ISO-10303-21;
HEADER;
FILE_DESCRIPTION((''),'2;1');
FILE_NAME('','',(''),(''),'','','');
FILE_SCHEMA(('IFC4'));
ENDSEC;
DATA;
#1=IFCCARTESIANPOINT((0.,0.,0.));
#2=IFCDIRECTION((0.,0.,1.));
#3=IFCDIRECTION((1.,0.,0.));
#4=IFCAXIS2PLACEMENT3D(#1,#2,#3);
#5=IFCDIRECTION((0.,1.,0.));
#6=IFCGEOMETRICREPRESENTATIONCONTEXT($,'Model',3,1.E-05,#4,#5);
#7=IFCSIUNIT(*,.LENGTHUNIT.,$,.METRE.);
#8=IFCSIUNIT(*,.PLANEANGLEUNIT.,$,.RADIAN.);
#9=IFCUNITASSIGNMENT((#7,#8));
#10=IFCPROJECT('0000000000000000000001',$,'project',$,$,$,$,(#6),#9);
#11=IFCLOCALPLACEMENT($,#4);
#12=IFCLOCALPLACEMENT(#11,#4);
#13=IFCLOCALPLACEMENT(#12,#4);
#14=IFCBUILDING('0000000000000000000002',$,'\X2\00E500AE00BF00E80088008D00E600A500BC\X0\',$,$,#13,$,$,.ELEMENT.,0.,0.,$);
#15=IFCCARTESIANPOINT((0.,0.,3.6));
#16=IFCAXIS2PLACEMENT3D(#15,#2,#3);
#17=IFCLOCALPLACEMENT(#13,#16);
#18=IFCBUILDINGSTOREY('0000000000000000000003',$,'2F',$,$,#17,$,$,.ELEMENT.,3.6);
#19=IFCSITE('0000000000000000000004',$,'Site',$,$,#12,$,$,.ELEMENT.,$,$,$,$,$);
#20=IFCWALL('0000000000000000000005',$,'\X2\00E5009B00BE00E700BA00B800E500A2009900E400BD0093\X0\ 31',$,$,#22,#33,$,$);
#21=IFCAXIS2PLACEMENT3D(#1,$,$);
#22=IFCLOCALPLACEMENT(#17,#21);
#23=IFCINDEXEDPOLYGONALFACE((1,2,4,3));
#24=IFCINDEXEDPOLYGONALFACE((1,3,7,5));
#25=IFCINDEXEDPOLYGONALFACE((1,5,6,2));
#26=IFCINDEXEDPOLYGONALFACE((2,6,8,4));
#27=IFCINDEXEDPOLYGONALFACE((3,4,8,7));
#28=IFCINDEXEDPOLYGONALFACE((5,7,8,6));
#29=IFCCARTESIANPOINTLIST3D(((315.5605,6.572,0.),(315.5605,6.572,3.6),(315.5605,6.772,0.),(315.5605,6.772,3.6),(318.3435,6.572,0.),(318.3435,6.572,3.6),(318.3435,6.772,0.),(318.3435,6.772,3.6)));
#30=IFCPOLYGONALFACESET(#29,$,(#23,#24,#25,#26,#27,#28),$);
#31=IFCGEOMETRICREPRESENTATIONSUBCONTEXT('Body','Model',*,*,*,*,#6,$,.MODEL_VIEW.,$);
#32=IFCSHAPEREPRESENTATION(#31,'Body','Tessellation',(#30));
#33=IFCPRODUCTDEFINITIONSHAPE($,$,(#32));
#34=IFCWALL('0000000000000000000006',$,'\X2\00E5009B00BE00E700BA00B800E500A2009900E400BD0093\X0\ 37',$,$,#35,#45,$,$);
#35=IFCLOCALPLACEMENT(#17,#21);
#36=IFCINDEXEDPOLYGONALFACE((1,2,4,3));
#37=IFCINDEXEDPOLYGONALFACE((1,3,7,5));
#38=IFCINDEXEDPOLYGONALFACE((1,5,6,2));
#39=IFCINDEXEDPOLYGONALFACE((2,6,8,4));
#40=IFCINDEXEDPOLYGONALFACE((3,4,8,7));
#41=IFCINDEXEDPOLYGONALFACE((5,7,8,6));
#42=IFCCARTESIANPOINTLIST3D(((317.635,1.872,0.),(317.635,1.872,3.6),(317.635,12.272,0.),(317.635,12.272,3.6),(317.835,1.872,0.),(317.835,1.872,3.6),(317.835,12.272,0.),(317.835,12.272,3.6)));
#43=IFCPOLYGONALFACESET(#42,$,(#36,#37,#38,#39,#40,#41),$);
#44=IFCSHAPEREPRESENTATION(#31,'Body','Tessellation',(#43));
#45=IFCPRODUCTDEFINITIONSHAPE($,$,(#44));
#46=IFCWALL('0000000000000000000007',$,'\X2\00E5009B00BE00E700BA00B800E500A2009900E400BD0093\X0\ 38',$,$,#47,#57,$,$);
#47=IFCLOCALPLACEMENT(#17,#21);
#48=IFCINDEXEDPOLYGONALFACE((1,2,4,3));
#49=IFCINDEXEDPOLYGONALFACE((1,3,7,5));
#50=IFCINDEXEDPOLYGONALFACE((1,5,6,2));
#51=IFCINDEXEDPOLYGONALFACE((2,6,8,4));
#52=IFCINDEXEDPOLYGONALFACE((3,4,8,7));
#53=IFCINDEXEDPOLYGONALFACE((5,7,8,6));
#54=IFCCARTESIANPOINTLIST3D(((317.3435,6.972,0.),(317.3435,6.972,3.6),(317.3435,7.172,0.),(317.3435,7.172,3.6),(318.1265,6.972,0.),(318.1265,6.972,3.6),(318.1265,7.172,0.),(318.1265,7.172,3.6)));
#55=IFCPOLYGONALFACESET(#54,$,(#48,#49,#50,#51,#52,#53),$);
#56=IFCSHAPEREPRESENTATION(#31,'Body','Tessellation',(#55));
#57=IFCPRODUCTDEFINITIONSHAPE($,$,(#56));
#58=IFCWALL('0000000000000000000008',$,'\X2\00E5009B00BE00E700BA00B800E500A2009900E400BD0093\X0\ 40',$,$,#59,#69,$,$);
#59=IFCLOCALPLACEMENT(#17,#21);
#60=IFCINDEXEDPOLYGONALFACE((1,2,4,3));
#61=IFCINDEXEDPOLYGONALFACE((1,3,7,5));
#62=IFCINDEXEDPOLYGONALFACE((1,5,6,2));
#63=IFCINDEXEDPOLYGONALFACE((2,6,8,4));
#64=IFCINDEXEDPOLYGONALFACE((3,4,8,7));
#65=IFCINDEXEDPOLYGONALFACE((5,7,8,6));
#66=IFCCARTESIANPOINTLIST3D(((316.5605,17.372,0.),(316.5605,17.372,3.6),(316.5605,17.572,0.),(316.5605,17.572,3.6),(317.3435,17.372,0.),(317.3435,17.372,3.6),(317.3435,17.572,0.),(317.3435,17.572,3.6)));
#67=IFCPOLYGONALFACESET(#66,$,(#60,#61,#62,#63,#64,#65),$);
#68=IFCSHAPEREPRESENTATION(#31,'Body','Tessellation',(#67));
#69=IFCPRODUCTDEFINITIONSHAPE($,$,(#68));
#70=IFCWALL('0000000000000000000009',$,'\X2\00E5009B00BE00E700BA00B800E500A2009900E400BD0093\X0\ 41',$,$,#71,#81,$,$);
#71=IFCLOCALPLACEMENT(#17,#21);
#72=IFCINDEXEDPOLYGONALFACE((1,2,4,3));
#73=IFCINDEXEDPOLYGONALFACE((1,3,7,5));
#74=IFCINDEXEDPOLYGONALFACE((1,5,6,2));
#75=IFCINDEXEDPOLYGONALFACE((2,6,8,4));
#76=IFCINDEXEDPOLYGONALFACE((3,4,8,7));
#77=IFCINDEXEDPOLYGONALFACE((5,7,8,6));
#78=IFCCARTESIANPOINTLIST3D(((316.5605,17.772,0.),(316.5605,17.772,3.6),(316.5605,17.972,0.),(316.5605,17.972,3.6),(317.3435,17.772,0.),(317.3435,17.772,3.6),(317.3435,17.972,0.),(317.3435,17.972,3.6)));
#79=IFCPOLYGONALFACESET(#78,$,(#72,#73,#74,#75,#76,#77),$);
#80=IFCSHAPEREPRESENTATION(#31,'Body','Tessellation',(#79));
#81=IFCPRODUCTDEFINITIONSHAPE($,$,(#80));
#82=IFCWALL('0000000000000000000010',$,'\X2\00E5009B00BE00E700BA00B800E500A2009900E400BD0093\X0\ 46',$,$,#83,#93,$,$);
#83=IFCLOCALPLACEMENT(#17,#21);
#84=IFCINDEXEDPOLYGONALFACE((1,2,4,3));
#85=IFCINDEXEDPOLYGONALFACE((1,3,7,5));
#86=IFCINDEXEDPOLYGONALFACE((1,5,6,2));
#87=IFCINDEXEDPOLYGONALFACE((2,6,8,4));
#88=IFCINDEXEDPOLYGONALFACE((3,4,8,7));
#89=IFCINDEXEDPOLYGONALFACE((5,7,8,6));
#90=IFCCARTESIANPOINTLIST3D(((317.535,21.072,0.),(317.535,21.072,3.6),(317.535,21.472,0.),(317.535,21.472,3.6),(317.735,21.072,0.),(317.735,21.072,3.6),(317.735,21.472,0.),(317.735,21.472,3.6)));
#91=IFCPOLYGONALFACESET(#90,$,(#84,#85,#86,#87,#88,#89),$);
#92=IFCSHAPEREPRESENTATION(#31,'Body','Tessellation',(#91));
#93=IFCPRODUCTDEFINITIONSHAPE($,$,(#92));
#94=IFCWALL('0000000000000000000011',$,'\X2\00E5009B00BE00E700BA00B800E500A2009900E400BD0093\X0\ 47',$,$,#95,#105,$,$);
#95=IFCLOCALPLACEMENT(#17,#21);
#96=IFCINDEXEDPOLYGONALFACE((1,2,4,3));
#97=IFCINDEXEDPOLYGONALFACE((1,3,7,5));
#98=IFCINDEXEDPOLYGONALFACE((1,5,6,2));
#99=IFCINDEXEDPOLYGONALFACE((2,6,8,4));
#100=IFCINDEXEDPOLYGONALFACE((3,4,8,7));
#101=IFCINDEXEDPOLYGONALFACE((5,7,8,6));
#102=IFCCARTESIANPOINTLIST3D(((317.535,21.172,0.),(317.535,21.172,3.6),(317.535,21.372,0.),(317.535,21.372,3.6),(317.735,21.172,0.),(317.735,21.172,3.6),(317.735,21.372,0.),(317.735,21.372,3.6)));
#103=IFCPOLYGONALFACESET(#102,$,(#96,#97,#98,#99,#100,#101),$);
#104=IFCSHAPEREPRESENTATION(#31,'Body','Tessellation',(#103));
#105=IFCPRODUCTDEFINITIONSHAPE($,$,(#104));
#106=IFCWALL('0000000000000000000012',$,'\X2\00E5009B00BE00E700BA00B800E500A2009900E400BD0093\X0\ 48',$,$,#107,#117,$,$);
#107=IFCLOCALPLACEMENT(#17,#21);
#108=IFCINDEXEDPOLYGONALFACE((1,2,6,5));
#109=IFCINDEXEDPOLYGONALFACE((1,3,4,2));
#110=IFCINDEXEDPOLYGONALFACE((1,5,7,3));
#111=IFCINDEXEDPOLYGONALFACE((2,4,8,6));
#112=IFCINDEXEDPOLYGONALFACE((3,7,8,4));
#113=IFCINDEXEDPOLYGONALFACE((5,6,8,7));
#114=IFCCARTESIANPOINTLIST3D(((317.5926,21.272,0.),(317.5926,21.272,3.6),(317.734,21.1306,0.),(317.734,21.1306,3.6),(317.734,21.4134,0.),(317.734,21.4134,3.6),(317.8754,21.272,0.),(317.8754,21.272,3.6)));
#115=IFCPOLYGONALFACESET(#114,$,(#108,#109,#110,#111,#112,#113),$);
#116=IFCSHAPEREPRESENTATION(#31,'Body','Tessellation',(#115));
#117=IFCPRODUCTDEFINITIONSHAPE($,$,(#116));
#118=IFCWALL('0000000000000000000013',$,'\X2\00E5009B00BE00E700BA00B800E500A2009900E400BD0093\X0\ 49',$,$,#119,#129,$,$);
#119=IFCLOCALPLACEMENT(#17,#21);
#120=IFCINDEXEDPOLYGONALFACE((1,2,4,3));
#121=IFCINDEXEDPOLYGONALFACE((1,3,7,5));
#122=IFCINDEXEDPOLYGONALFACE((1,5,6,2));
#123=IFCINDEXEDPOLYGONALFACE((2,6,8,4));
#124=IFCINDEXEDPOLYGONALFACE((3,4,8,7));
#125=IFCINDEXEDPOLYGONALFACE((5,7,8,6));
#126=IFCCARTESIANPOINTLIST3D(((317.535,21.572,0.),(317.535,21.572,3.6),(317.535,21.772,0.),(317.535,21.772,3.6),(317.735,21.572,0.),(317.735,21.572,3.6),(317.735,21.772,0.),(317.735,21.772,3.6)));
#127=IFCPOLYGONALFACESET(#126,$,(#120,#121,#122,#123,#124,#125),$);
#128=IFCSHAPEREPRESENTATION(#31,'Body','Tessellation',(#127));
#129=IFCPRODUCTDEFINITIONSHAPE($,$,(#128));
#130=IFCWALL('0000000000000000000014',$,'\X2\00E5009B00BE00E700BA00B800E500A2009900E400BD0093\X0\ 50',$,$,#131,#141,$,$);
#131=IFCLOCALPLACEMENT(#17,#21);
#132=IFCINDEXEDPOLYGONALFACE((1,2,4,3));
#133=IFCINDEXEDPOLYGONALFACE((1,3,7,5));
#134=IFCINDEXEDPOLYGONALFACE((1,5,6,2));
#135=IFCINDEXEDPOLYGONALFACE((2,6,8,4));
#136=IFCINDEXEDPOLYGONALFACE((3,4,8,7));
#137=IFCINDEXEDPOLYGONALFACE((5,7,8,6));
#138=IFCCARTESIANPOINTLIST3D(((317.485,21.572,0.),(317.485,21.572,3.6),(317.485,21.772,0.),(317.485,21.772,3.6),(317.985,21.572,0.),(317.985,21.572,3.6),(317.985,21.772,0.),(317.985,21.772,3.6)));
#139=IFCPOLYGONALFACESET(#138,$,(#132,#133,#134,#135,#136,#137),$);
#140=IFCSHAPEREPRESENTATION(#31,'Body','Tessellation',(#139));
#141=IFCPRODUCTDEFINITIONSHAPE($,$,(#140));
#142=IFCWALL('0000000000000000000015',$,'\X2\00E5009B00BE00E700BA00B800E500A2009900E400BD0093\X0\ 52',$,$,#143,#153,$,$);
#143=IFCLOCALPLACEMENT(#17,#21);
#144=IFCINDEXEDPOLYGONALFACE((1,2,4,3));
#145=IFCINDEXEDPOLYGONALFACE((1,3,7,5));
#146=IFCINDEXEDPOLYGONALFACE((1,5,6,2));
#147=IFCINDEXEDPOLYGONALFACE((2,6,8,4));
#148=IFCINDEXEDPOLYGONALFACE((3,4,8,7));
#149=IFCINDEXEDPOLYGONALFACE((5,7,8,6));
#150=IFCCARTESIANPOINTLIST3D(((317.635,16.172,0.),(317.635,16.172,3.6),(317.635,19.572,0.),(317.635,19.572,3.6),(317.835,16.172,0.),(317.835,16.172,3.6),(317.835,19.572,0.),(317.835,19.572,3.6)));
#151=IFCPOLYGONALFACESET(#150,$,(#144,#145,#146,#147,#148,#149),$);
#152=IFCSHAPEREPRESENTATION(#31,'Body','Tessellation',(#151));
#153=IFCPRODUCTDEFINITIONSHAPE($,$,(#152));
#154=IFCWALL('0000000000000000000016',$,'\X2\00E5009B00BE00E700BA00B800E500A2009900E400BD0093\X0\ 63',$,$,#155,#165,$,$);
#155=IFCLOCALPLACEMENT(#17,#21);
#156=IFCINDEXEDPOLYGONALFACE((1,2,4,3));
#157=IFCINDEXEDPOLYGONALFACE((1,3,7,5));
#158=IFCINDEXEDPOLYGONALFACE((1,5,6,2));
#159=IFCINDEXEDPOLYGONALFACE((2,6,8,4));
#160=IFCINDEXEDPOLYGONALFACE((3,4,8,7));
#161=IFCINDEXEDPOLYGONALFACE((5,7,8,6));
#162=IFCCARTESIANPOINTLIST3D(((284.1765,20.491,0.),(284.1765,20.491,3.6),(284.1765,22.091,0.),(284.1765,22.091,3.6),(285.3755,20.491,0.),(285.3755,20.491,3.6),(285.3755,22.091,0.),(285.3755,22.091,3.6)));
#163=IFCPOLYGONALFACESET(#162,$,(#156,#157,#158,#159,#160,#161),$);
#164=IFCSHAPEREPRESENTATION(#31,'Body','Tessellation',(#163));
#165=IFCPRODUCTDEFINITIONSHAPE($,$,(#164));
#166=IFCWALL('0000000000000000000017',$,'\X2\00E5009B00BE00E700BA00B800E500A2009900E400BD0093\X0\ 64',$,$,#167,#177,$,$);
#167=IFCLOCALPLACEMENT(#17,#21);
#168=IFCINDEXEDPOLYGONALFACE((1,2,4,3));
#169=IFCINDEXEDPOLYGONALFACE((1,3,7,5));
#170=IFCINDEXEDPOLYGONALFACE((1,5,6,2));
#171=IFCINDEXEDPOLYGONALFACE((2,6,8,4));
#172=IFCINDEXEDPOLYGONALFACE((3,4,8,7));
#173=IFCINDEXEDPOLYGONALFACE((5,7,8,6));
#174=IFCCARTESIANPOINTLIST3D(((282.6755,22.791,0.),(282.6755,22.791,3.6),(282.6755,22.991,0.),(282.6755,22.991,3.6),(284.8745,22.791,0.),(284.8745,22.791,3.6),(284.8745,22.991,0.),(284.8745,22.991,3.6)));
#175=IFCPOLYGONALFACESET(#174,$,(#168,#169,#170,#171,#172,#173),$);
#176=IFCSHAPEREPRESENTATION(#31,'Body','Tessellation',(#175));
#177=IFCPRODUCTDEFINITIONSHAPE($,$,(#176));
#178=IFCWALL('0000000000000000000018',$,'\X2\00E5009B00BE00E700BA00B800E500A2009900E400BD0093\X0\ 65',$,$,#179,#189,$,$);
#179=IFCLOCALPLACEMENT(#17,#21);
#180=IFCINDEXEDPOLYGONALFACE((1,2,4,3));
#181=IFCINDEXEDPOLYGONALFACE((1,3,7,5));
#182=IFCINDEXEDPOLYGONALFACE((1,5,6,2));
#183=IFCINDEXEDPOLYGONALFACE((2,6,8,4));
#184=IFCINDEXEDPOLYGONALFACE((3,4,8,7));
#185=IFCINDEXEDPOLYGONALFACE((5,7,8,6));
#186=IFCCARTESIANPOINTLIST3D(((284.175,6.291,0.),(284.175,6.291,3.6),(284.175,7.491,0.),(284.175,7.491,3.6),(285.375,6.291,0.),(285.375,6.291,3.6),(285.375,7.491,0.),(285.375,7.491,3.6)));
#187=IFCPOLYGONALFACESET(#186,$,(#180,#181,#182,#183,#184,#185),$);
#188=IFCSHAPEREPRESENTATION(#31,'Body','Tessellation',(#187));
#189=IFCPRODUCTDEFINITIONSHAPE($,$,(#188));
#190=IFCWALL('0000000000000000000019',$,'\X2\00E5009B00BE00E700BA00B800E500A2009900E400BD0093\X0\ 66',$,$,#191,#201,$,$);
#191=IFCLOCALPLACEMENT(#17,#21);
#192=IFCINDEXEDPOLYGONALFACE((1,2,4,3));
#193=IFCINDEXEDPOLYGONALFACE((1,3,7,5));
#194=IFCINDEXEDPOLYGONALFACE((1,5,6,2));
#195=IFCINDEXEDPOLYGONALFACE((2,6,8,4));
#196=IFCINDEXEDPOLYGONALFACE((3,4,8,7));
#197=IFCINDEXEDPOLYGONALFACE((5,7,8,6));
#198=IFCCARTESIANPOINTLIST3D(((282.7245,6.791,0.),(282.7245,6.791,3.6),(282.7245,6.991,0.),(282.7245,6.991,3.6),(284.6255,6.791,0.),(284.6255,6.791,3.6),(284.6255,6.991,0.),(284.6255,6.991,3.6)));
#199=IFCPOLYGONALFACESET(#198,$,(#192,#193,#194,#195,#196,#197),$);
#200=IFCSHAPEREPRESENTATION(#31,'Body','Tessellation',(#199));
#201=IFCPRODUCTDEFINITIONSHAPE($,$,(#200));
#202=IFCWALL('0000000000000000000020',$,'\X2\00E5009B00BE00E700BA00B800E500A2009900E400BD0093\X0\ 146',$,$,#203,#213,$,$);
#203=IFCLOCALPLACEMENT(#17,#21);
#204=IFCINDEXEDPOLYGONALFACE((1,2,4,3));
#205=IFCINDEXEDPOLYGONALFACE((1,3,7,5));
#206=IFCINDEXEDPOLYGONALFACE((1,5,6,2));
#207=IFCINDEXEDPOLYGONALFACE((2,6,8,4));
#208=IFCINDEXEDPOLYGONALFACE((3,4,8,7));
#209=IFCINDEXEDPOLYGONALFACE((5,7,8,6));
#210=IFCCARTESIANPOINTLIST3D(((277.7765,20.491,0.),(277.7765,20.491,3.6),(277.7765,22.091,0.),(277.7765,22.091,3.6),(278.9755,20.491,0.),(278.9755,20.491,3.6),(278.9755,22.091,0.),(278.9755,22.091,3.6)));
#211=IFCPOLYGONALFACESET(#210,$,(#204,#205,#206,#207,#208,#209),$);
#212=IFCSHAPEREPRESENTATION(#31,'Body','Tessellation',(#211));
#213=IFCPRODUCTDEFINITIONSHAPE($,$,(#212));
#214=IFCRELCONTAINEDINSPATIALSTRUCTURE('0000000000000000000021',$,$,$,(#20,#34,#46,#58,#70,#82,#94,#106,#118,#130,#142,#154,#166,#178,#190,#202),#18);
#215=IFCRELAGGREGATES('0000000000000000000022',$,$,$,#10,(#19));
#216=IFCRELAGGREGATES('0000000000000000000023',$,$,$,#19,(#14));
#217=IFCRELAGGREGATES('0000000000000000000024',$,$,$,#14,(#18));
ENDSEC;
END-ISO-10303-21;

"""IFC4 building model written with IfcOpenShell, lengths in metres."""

from ifc_helpers import new_model, si_unit, direction, frame, frame_2d, origin_with_axes, place, context, subcontext, project, spatial, rectangle, extrude, element, save


model = new_model("IFC4")

# Units and contexts
model_context = context("Model", 3, precision=1e-05, world=origin_with_axes(), true_north=direction((0.0, 1.0, 0.0)))
body_context = subcontext(model_context, "Body", "Model", "MODEL_VIEW")
ifc_project = project(units=[si_unit("LENGTHUNIT", "METRE"), si_unit("PLANEANGLEUNIT", "RADIAN")], contexts=[model_context])

# Site, building, storey
placement = place(None, origin_with_axes())
site_placement = place(placement, origin_with_axes())
site = spatial("IfcSite", under=ifc_project, at=site_placement, Name="Site", CompositionType="ELEMENT")
building_placement = place(site_placement, origin_with_axes())
building = spatial("IfcBuilding", under=site, at=building_placement, Name="å®¿è\u0088\u008dæ¥¼", CompositionType="ELEMENT", ElevationOfRefHeight=0.0, ElevationOfTerrain=0.0)
storey_placement = place(building_placement, frame((0.0, 0.0, 3.6), z_axis=(0.0, 0.0, 1.0), x_axis=(1.0, 0.0, 0.0)))
storey = spatial("IfcBuildingStorey", under=building, at=storey_placement, Name="2F", CompositionType="ELEMENT", Elevation=3.6)

# Walls
wall_1_placement = place(storey_placement, frame((316.952, 6.672, 0.0), z_axis=(0.0, 0.0, 1.0), x_axis=(1.0, 0.0, 0.0)))
element("IfcWall", 1, at=wall_1_placement, inside=storey, Name="å\u009b¾çº¸å¢\u0099ä½\u0093 31", context=body_context, shape_type="SweptSolid", body=[
    extrude(rectangle(XDim=2.783, YDim=0.2, at=frame_2d((0.0, 0.0), x_axis=(1.0, 0.0, 0.0))), frame((0.0, 0.0, 0.0), z_axis=(0.0, 0.0, 1.0)), (0.0, 0.0, 1.0), 3.6),
])
wall_2_placement = place(storey_placement, frame((317.735, 7.072, 0.0), z_axis=(0.0, 0.0, 1.0), x_axis=(0.0, 1.0, 0.0)))
element("IfcWall", 2, at=wall_2_placement, inside=storey, Name="å\u009b¾çº¸å¢\u0099ä½\u0093 37", context=body_context, shape_type="SweptSolid", body=[
    extrude(rectangle(XDim=10.4, YDim=0.2, at=frame_2d((0.0, 0.0), x_axis=(1.0, 0.0, 0.0))), frame((0.0, 0.0, 0.0), z_axis=(0.0, 0.0, 1.0)), (0.0, 0.0, 1.0), 3.6),
])
for number, where, z_axis, x_axis, name in (
    (3, (317.735, 7.072, 0.0), (0.0, 0.0, 1.0), (-1.0, 0.0, 0.0), "å\u009b¾çº¸å¢\u0099ä½\u0093 38"),
    (4, (316.952, 17.472, 0.0), (0.0, 0.0, 1.0), (1.0, 0.0, 0.0), "å\u009b¾çº¸å¢\u0099ä½\u0093 40"),
    (5, (316.952, 17.872, 0.0), (0.0, 0.0, 1.0), (1.0, 0.0, 0.0), "å\u009b¾çº¸å¢\u0099ä½\u0093 41"),
):
    element("IfcWall", number, at=place(storey_placement, frame(where, z_axis=z_axis, x_axis=x_axis)), inside=storey, Name=name, context=body_context, shape_type="SweptSolid", body=[
        extrude(rectangle(XDim=0.783, YDim=0.2, at=frame_2d((0.0, 0.0), x_axis=(1.0, 0.0, 0.0))), frame((0.0, 0.0, 0.0), z_axis=(0.0, 0.0, 1.0)), (0.0, 0.0, 1.0), 3.6),
    ])
wall_3_placement = place(storey_placement, frame((317.635, 21.272, 0.0), z_axis=(0.0, 0.0, 1.0), x_axis=(0.0, 1.0, 0.0)))
element("IfcWall", 6, at=wall_3_placement, inside=storey, Name="å\u009b¾çº¸å¢\u0099ä½\u0093 46", context=body_context, shape_type="SweptSolid", body=[
    extrude(rectangle(XDim=0.4, YDim=0.2, at=frame_2d((0.0, 0.0), x_axis=(1.0, 0.0, 0.0))), frame((0.0, 0.0, 0.0), z_axis=(0.0, 0.0, 1.0)), (0.0, 0.0, 1.0), 3.6),
])
for number, where, z_axis, x_axis, name in (
    (7, (317.635, 21.272, 0.0), (0.0, 0.0, 1.0), (1.0, 0.0, 0.0), "å\u009b¾çº¸å¢\u0099ä½\u0093 47"),
    (8, (317.734, 21.272, 0.0), (0.0, 0.0, 1.0), (0.707107, -0.707107, 0.0), "å\u009b¾çº¸å¢\u0099ä½\u0093 48"),
    (9, (317.635, 21.672, 0.0), (0.0, 0.0, 1.0), (1.0, 0.0, 0.0), "å\u009b¾çº¸å¢\u0099ä½\u0093 49"),
):
    element("IfcWall", number, at=place(storey_placement, frame(where, z_axis=z_axis, x_axis=x_axis)), inside=storey, Name=name, context=body_context, shape_type="SweptSolid", body=[
        extrude(rectangle(XDim=0.2, YDim=0.2, at=frame_2d((0.0, 0.0), x_axis=(1.0, 0.0, 0.0))), frame((0.0, 0.0, 0.0), z_axis=(0.0, 0.0, 1.0)), (0.0, 0.0, 1.0), 3.6),
    ])
wall_4_placement = place(storey_placement, frame((317.735, 21.672, 0.0), z_axis=(0.0, 0.0, 1.0), x_axis=(1.0, 0.0, 0.0)))
element("IfcWall", 10, at=wall_4_placement, inside=storey, Name="å\u009b¾çº¸å¢\u0099ä½\u0093 50", context=body_context, shape_type="SweptSolid", body=[
    extrude(rectangle(XDim=0.5, YDim=0.2, at=frame_2d((0.0, 0.0), x_axis=(1.0, 0.0, 0.0))), frame((0.0, 0.0, 0.0), z_axis=(0.0, 0.0, 1.0)), (0.0, 0.0, 1.0), 3.6),
])
wall_5_placement = place(storey_placement, frame((317.735, 17.872, 0.0), z_axis=(0.0, 0.0, 1.0), x_axis=(0.0, 1.0, 0.0)))
element("IfcWall", 11, at=wall_5_placement, inside=storey, Name="å\u009b¾çº¸å¢\u0099ä½\u0093 52", context=body_context, shape_type="SweptSolid", body=[
    extrude(rectangle(XDim=3.4, YDim=0.2, at=frame_2d((0.0, 0.0), x_axis=(1.0, 0.0, 0.0))), frame((0.0, 0.0, 0.0), z_axis=(0.0, 0.0, 1.0)), (0.0, 0.0, 1.0), 3.6),
])
wall_6_placement = place(storey_placement, frame((284.776, 21.291, 0.0), z_axis=(0.0, 0.0, 1.0), x_axis=(1.0, 0.0, 0.0)))
element("IfcWall", 12, at=wall_6_placement, inside=storey, Name="å\u009b¾çº¸å¢\u0099ä½\u0093 63", context=body_context, shape_type="SweptSolid", body=[
    extrude(rectangle(XDim=1.199, YDim=1.6, at=frame_2d((0.0, 0.0), x_axis=(1.0, 0.0, 0.0))), frame((0.0, 0.0, 0.0), z_axis=(0.0, 0.0, 1.0)), (0.0, 0.0, 1.0), 3.6),
])
wall_7_placement = place(storey_placement, frame((283.775, 22.891, 0.0), z_axis=(0.0, 0.0, 1.0), x_axis=(1.0, 0.0, 0.0)))
element("IfcWall", 13, at=wall_7_placement, inside=storey, Name="å\u009b¾çº¸å¢\u0099ä½\u0093 64", context=body_context, shape_type="SweptSolid", body=[
    extrude(rectangle(XDim=2.199, YDim=0.2, at=frame_2d((0.0, 0.0), x_axis=(1.0, 0.0, 0.0))), frame((0.0, 0.0, 0.0), z_axis=(0.0, 0.0, 1.0)), (0.0, 0.0, 1.0), 3.6),
])
wall_8_placement = place(storey_placement, frame((284.775, 6.891, 0.0), z_axis=(0.0, 0.0, 1.0), x_axis=(1.0, 0.0, 0.0)))
element("IfcWall", 14, at=wall_8_placement, inside=storey, Name="å\u009b¾çº¸å¢\u0099ä½\u0093 65", context=body_context, shape_type="SweptSolid", body=[
    extrude(rectangle(XDim=1.2, YDim=1.2, at=frame_2d((0.0, 0.0), x_axis=(1.0, 0.0, 0.0))), frame((0.0, 0.0, 0.0), z_axis=(0.0, 0.0, 1.0)), (0.0, 0.0, 1.0), 3.6),
])
wall_9_placement = place(storey_placement, frame((283.675, 6.891, 0.0), z_axis=(0.0, 0.0, 1.0), x_axis=(1.0, 0.0, 0.0)))
element("IfcWall", 15, at=wall_9_placement, inside=storey, Name="å\u009b¾çº¸å¢\u0099ä½\u0093 66", context=body_context, shape_type="SweptSolid", body=[
    extrude(rectangle(XDim=1.901, YDim=0.2, at=frame_2d((0.0, 0.0), x_axis=(1.0, 0.0, 0.0))), frame((0.0, 0.0, 0.0), z_axis=(0.0, 0.0, 1.0)), (0.0, 0.0, 1.0), 3.6),
])
wall_10_placement = place(storey_placement, frame((278.376, 21.291, 0.0), z_axis=(0.0, 0.0, 1.0), x_axis=(1.0, 0.0, 0.0)))
element("IfcWall", 16, at=wall_10_placement, inside=storey, Name="å\u009b¾çº¸å¢\u0099ä½\u0093 146", context=body_context, shape_type="SweptSolid", body=[
    extrude(rectangle(XDim=1.199, YDim=1.6, at=frame_2d((0.0, 0.0), x_axis=(1.0, 0.0, 0.0))), frame((0.0, 0.0, 0.0), z_axis=(0.0, 0.0, 1.0)), (0.0, 0.0, 1.0), 3.6),
])

save(model, "model.ifc")
